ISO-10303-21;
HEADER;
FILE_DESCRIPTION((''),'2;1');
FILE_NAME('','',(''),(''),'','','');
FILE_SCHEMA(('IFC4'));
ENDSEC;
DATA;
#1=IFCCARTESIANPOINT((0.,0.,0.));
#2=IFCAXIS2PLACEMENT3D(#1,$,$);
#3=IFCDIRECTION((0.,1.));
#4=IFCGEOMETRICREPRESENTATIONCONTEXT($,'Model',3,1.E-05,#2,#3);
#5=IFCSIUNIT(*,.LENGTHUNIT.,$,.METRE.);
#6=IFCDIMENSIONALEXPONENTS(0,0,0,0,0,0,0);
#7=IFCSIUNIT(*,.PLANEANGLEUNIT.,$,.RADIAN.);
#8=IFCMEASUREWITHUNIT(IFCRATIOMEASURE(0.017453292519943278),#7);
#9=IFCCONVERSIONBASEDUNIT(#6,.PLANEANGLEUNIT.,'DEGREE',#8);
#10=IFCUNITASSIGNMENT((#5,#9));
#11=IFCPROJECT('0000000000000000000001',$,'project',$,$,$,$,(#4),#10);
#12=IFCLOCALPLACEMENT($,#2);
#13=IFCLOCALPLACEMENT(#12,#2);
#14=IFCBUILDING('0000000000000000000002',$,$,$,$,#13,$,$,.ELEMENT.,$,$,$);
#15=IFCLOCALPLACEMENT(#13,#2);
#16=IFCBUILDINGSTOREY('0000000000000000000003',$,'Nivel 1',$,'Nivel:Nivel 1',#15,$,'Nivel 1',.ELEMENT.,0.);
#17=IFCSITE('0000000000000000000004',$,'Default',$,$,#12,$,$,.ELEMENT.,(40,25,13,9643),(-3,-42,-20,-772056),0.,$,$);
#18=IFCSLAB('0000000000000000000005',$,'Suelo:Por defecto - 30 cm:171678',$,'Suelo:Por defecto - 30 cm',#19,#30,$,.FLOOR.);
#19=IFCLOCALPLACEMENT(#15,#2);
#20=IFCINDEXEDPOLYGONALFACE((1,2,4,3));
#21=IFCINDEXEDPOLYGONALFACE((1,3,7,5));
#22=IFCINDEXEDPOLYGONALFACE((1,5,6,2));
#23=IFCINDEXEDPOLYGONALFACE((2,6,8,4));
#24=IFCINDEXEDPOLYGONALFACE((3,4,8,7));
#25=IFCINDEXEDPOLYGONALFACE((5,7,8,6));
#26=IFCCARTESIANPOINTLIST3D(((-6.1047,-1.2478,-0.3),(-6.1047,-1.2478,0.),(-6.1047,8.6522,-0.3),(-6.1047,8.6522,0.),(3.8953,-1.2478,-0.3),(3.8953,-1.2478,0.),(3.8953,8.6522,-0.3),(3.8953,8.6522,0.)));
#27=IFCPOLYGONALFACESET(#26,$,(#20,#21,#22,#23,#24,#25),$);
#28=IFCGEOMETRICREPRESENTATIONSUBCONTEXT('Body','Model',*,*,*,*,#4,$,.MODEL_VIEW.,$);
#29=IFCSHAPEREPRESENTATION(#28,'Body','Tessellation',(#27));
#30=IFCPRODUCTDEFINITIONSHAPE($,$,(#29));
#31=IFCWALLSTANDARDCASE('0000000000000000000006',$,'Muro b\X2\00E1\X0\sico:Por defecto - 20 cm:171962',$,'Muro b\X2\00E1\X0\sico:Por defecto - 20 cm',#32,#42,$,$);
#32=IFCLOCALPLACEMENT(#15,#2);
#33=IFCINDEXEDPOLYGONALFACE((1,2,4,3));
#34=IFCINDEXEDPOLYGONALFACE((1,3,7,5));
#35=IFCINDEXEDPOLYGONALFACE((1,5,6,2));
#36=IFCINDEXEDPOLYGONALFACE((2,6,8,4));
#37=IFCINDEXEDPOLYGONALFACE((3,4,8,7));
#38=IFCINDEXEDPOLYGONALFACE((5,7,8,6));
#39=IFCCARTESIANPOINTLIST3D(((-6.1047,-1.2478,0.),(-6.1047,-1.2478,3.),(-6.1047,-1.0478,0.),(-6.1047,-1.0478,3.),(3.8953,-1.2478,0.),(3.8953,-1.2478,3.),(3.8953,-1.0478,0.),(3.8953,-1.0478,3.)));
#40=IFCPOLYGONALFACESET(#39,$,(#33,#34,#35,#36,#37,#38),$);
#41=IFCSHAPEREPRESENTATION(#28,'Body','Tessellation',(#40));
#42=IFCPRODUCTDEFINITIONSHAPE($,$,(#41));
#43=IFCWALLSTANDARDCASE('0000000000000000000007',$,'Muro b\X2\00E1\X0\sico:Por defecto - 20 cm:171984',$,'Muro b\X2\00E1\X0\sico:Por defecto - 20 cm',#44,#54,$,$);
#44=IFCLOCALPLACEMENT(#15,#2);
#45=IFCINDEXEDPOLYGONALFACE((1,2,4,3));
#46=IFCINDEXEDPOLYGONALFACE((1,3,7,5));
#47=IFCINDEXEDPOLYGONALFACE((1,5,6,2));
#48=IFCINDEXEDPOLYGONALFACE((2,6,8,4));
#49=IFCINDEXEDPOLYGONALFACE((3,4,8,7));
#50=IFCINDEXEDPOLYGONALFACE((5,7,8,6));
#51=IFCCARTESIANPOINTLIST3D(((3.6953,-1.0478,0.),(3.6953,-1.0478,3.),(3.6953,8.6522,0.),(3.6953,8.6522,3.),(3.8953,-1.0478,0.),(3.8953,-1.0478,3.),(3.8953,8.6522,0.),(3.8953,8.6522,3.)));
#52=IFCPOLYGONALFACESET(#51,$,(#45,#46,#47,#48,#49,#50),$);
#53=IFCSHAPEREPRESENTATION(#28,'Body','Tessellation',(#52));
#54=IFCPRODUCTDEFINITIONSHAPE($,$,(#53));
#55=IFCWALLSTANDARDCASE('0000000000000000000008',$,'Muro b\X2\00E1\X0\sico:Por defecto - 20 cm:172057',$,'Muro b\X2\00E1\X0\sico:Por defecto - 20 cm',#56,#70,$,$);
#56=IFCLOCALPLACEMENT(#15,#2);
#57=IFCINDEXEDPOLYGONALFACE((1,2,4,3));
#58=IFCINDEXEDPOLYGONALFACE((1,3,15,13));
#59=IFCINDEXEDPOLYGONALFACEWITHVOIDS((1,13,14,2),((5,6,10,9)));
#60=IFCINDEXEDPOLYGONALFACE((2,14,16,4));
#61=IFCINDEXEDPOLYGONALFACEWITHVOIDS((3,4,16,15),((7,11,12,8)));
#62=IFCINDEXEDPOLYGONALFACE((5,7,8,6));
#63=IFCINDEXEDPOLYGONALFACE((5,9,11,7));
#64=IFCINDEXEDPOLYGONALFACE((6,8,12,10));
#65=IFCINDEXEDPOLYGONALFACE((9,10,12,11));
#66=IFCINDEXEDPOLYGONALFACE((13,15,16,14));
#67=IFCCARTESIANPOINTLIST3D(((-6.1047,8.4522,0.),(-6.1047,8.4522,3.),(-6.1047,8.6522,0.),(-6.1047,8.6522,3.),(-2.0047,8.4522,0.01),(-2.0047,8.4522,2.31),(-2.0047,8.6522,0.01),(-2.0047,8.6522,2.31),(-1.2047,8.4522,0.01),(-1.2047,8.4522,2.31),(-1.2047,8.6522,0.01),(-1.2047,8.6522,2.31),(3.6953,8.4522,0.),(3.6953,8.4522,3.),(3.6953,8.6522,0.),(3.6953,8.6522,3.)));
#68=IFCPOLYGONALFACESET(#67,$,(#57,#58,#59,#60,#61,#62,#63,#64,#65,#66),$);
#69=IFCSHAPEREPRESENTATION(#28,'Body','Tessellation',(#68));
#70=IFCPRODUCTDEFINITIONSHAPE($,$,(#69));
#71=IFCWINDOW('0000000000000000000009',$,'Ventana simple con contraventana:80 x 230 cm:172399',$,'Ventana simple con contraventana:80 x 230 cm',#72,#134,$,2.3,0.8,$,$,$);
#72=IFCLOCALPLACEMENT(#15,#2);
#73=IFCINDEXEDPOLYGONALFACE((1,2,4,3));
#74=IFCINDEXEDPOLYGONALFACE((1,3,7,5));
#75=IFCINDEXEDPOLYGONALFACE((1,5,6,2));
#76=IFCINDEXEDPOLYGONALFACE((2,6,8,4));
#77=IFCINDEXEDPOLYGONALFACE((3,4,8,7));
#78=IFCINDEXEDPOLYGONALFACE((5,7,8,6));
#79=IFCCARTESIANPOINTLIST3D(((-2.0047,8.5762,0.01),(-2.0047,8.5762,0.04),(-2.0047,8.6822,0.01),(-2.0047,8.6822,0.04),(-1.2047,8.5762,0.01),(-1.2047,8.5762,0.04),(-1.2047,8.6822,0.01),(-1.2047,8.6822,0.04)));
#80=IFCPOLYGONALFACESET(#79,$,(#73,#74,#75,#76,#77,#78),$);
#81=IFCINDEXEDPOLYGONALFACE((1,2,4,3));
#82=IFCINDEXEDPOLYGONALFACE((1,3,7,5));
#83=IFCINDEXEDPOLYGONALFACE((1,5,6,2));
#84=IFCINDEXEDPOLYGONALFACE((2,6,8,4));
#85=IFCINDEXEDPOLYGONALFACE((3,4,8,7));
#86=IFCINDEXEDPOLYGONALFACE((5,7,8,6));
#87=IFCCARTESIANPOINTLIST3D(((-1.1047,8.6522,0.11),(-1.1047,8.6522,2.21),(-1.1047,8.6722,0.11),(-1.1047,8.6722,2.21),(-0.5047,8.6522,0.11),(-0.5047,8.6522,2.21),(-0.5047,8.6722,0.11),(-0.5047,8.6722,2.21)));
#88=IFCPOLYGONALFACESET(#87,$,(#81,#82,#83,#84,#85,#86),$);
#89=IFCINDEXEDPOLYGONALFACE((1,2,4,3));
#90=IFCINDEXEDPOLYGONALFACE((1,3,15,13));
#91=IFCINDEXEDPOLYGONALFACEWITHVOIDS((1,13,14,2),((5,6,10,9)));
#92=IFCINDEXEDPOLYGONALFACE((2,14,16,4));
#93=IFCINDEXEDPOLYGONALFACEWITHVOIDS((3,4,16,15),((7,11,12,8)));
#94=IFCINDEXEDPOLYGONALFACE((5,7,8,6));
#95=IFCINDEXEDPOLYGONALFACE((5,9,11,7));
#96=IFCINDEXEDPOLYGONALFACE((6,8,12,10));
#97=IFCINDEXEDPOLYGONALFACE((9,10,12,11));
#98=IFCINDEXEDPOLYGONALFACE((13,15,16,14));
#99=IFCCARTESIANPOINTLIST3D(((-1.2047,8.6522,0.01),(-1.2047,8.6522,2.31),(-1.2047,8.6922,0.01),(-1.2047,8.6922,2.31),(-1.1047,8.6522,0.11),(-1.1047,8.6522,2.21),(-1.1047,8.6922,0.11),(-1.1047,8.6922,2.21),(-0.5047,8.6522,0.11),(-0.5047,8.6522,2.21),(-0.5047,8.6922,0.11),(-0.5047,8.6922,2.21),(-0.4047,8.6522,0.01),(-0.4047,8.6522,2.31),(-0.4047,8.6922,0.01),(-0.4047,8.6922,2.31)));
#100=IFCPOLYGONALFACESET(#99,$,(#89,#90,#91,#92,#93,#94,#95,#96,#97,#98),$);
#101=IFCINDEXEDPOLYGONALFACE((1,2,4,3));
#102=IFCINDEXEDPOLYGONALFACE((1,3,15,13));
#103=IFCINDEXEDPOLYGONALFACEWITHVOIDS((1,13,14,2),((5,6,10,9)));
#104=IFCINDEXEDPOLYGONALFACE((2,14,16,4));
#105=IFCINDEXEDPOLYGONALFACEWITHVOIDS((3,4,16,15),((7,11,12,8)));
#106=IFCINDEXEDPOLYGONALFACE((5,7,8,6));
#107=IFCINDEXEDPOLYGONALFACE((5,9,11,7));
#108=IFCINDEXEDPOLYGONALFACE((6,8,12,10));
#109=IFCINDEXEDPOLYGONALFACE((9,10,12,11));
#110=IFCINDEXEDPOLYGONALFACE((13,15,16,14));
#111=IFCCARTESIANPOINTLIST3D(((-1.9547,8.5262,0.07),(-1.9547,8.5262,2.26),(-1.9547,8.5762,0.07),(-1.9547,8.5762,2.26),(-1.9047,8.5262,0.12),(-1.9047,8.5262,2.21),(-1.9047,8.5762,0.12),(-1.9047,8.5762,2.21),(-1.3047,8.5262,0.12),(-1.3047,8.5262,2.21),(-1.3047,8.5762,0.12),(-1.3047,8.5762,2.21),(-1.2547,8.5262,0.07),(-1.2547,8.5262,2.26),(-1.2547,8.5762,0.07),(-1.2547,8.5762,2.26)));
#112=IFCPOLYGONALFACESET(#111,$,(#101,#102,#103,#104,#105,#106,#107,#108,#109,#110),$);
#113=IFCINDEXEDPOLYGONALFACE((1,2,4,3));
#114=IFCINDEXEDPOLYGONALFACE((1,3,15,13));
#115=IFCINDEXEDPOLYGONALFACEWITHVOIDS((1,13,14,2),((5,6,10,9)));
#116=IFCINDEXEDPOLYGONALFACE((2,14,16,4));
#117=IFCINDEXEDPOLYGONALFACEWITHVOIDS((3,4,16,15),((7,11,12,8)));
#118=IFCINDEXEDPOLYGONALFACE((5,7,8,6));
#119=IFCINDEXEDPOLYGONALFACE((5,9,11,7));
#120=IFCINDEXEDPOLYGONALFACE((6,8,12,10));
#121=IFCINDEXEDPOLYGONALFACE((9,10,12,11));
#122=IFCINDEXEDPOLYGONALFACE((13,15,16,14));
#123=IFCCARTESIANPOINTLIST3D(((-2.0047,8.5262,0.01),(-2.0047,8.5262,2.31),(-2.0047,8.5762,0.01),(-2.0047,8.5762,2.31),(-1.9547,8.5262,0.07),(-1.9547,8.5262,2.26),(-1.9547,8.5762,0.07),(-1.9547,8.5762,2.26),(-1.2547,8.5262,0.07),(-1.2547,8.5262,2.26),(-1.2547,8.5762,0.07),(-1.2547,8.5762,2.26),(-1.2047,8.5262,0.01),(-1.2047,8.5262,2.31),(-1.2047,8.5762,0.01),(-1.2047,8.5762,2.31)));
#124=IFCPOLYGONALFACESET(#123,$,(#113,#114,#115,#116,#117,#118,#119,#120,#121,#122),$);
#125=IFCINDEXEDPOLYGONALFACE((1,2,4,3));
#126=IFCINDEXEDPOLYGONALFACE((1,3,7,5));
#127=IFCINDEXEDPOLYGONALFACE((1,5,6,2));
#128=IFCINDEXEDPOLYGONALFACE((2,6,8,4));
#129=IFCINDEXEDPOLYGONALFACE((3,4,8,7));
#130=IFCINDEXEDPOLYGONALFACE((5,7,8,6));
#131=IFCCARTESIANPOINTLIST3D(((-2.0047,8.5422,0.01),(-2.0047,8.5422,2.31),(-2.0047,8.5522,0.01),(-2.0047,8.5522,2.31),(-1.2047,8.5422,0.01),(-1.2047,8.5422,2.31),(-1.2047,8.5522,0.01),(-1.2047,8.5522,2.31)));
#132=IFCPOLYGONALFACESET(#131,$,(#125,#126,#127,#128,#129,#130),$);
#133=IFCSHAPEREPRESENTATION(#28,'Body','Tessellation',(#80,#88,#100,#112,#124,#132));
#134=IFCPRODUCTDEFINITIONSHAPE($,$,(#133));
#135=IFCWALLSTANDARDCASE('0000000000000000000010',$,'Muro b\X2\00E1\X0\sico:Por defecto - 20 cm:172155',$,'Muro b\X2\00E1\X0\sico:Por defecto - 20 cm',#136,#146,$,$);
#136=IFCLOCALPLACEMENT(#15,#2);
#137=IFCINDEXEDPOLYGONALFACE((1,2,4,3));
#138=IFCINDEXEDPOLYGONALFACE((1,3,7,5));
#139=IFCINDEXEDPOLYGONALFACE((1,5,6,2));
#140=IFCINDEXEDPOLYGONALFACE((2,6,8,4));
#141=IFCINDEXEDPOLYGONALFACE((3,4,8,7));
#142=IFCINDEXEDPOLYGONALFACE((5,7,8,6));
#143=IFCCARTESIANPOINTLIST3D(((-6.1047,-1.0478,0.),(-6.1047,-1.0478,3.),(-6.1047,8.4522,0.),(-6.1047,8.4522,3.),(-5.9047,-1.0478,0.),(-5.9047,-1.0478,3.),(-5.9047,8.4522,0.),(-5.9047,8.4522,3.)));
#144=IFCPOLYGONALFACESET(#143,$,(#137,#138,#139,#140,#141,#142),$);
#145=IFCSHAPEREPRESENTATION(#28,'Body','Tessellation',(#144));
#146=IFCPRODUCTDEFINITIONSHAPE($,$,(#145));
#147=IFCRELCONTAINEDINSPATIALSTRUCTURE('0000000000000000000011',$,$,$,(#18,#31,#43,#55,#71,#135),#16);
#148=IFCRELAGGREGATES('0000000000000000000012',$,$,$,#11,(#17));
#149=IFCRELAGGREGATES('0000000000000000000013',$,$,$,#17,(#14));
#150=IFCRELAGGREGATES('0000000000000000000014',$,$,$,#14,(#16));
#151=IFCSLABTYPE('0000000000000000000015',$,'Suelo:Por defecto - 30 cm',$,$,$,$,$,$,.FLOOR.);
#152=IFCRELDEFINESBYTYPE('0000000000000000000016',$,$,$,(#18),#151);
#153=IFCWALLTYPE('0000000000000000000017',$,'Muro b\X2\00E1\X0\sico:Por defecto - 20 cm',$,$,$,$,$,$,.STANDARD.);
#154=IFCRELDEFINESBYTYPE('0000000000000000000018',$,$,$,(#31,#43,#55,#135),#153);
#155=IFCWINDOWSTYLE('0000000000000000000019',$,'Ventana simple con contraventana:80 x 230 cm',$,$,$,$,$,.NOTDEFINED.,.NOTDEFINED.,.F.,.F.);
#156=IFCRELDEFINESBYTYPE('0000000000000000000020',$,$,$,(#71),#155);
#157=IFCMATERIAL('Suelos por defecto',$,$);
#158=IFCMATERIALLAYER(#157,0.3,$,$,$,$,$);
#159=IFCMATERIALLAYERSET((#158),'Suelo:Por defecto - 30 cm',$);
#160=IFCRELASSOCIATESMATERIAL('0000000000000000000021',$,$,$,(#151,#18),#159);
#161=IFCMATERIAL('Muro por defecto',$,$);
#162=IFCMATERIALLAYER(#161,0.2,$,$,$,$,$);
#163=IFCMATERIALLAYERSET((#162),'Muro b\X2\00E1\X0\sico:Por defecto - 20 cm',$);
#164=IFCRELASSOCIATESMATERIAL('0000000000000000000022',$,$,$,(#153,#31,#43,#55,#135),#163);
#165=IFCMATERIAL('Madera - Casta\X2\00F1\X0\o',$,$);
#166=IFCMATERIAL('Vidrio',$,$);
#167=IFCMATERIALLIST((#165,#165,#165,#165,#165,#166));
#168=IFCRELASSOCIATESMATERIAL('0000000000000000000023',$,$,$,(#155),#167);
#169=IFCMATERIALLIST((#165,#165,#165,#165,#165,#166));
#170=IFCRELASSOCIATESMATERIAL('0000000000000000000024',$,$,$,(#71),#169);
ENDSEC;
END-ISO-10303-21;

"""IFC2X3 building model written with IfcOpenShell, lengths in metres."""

from ifc_helpers import new_model, entity, si_unit, converted_unit, direction, frame, frame_2d, origin, origin_2d_with_axis, place, context, subcontext, project, spatial, polyline, rectangle, outline, extrude, source, transform, mapped, material, material_list, layer, layer_set, layer_usage, type_object, type_shapes, element, fill, save


model = new_model("IFC2X3")

# Units and contexts
model_context = context("Model", 3, precision=1e-05, world=origin(), true_north=direction((0.0, 1.0)))
body_context = subcontext(model_context, "Body", "Model", "MODEL_VIEW")
ifc_project = project(units=[si_unit("LENGTHUNIT", "METRE"), converted_unit("PLANEANGLEUNIT", "DEGREE", entity("IfcRatioMeasure", 0.017453292519943278), si_unit("PLANEANGLEUNIT", "RADIAN"), dimensions=[0, 0, 0, 0, 0, 0, 0])], contexts=[model_context])

# Site, building, storey
site_placement = place(None, origin())
site = spatial("IfcSite", under=ifc_project, at=site_placement, Name="Default", CompositionType="ELEMENT", RefLatitude=(40, 25, 13, 9643), RefLongitude=(-3, -42, -20, -772056), RefElevation=0.0)
building_placement = place(site_placement, origin())
building = spatial("IfcBuilding", under=site, at=building_placement, CompositionType="ELEMENT")
storey_placement = place(building_placement, origin())
storey = spatial("IfcBuildingStorey", under=building, at=storey_placement, Name="Nivel 1", ObjectType="Nivel:Nivel 1", LongName="Nivel 1", CompositionType="ELEMENT", Elevation=0.0)

# Slab
ifc_material_1 = material(Name="Suelos por defecto")
ifc_layer_1 = layer(ifc_material_1, 0.3)
ifc_layer_set_1 = layer_set([ifc_layer_1], Name="Suelo:Por defecto - 30 cm")
ifc_layer_usage_1 = layer_usage(ifc_layer_set_1, "AXIS3", "POSITIVE", 0.0)
slab_type = type_object("IfcSlabType", Name="Suelo:Por defecto - 30 cm", PredefinedType="FLOOR", material=ifc_layer_set_1)
slab_placement = place(storey_placement, origin())
element("IfcSlab", 1, at=slab_placement, inside=storey, type_object=slab_type, material=ifc_layer_usage_1, Name="Suelo:Por defecto - 30 cm:171678", ObjectType="Suelo:Por defecto - 30 cm", PredefinedType="FLOOR", context=body_context, shape_type="SweptSolid", body=[
    extrude(rectangle(XDim=9.9, YDim=10.0, at=origin_2d_with_axis()), frame((-1.1047, 3.7022, 0.0), z_axis=(0.0, 0.0, -1.0), x_axis=(0.0, 1.0, 0.0)), (0.0, 0.0, 1.0), 0.3),
])

# Walls
ifc_material_2 = material(Name="Muro por defecto")
ifc_layer_2 = layer(ifc_material_2, 0.2)
ifc_layer_set_2 = layer_set([ifc_layer_2], Name="Muro básico:Por defecto - 20 cm")
ifc_layer_usage_2 = layer_usage(ifc_layer_set_2, "AXIS2", "NEGATIVE", 0.1)
wall_type = type_object("IfcWallType", Name="Muro básico:Por defecto - 20 cm", PredefinedType="STANDARD", material=ifc_layer_set_2)
wall_1_placement = place(storey_placement, frame((-6.1047, -1.1478, 0.0)))
element("IfcWallStandardCase", 2, at=wall_1_placement, inside=storey, type_object=wall_type, material=ifc_layer_usage_2, Name="Muro básico:Por defecto - 20 cm:171962", ObjectType="Muro básico:Por defecto - 20 cm", context=body_context, shape_type="SweptSolid", body=[
    extrude(rectangle(XDim=10.0, YDim=0.2, at=frame_2d((5.0, 0.0), x_axis=(-1.0, 0.0))), origin(), (0.0, 0.0, 1.0), 3.0),
])
ifc_layer_usage_3 = layer_usage(ifc_layer_set_2, "AXIS2", "NEGATIVE", 0.1)
wall_2_placement = place(storey_placement, frame((3.7953, -1.0478, 0.0), z_axis=(0.0, 0.0, 1.0), x_axis=(0.0, 1.0, 0.0)))
element("IfcWallStandardCase", 3, at=wall_2_placement, inside=storey, type_object=wall_type, material=ifc_layer_usage_3, Name="Muro básico:Por defecto - 20 cm:171984", ObjectType="Muro básico:Por defecto - 20 cm", context=body_context, shape_type="SweptSolid", body=[
    extrude(rectangle(XDim=9.7, YDim=0.2, at=frame_2d((4.85, 0.0), x_axis=(-1.0, 0.0))), origin(), (0.0, 0.0, 1.0), 3.0),
])

# Wall, opening, window
ifc_layer_usage_4 = layer_usage(ifc_layer_set_2, "AXIS2", "NEGATIVE", 0.1)
wall_3_placement = place(storey_placement, frame((3.6953, 8.5522, 0.0), z_axis=(0.0, 0.0, 1.0), x_axis=(-1.0, 0.0, 0.0)))
wall_3 = element("IfcWallStandardCase", 4, at=wall_3_placement, inside=storey, type_object=wall_type, material=ifc_layer_usage_4, Name="Muro básico:Por defecto - 20 cm:172057", ObjectType="Muro básico:Por defecto - 20 cm", context=body_context, shape_type="SweptSolid", body=[
    extrude(rectangle(XDim=9.8, YDim=0.2, at=frame_2d((4.9, 0.0), x_axis=(-1.0, 0.0))), origin(), (0.0, 0.0, 1.0), 3.0),
])
opening_placement = place(wall_3_placement, frame((5.7, 0.1, 0.01)))
opening = element("IfcOpeningElement", 5, at=opening_placement, cuts=wall_3, ObjectType="Opening", context=body_context, shape_type="SweptSolid", body=[
    extrude(rectangle(XDim=2.3, YDim=0.8, at=frame_2d((1.15, 0.4), x_axis=(1.0, 0.0))), frame((0.0, 0.0, 0.0), z_axis=(0.0, -1.0, 0.0), x_axis=(0.0, 0.0, 1.0)), (0.0, 0.0, 1.0), 0.2),
])
ifc_material_3 = material(Name="Madera - Castaño")
ifc_material_4 = material(Name="Vidrio")
ifc_material_list_1 = material_list([ifc_material_3, ifc_material_3, ifc_material_3, ifc_material_3, ifc_material_3, ifc_material_4])
ifc_material_list_2 = material_list([ifc_material_3, ifc_material_3, ifc_material_3, ifc_material_3, ifc_material_3, ifc_material_4])
window_style = type_object("IfcWindowStyle", Name="Ventana simple con contraventana:80 x 230 cm", ConstructionType="NOTDEFINED", OperationType="NOTDEFINED", ParameterTakesPrecedence=False, Sizeable=False, material=ifc_material_list_2)
shared_shape = source(origin(), body_context, "Body", "SweptSolid", [
    extrude(rectangle(XDim=0.8, YDim=0.106, at=frame_2d((0.0, 0.0), x_axis=(1.0, 0.0))), frame((0.4, 0.177, 0.0)), (0.0, 0.0, 1.0), 0.03),
    extrude(rectangle(XDim=0.02, YDim=0.6, at=frame_2d((0.0, 0.0), x_axis=(1.0, 0.0))), frame((1.2, 0.21, 0.1), z_axis=(0.0, 0.0, 1.0), x_axis=(0.0, 1.0, 0.0)), (0.0, 0.0, 1.0), 2.1),
    extrude(outline(polyline([(-1.15, -0.4), (1.15, -0.4), (1.15, 0.4), (-1.15, 0.4), (-1.15, -0.4)]), holes=[polyline([(-1.05, 0.3), (1.05, 0.3), (1.05, -0.3), (-1.05, -0.3), (-1.05, 0.3)])]), frame((1.2, 0.2, 1.15), z_axis=(0.0, 1.0, 0.0), x_axis=(0.0, 0.0, -1.0)), (0.0, 0.0, 1.0), 0.04),
    extrude(outline(polyline([(-1.095, -0.35), (1.095, -0.35), (1.095, 0.35), (-1.095, 0.35), (-1.095, -0.35)]), holes=[polyline([(-1.045, -0.3), (-1.045, 0.3), (1.045, 0.3), (1.045, -0.3), (-1.045, -0.3)])]), frame((0.4, 0.074, 1.155), z_axis=(0.0, 1.0, 0.0), x_axis=(0.0, 0.0, -1.0)), (0.0, 0.0, 1.0), 0.05),
    extrude(outline(polyline([(-0.4, -1.15), (0.4, -1.15), (0.4, 1.15), (-0.4, 1.15), (-0.4, -1.15)]), holes=[polyline([(-0.35, -1.1), (-0.35, 1.09), (0.35, 1.09), (0.35, -1.1), (-0.35, -1.1)])]), frame((0.4, 0.074, 1.15), z_axis=(0.0, 1.0, 0.0), x_axis=(1.0, 0.0, 0.0)), (0.0, 0.0, 1.0), 0.05),
    extrude(rectangle(XDim=0.01, YDim=0.8, at=origin_2d_with_axis()), frame((0.4, 0.095, 0.0), z_axis=(0.0, 0.0, 1.0), x_axis=(0.0, 1.0, 0.0)), (0.0, 0.0, 1.0), 2.3),
])
type_shapes(window_style, [shared_shape])
window_placement = place(opening_placement, frame((0.0, 0.0, 0.0), z_axis=(0.0, 0.0, 1.0), x_axis=(-1.0, 0.0, 0.0)))
window = element("IfcWindow", 6, at=window_placement, inside=storey, type_object=window_style, material=ifc_material_list_1, Name="Ventana simple con contraventana:80 x 230 cm:172399", ObjectType="Ventana simple con contraventana:80 x 230 cm", OverallHeight=2.3, OverallWidth=0.8, context=body_context, shape_type="MappedRepresentation", body=[
    mapped(shared_shape, transform((0.0, 0.0, 0.0), scale=1.0)),
])
fill(opening, window)

# Wall
ifc_layer_usage_5 = layer_usage(ifc_layer_set_2, "AXIS2", "NEGATIVE", 0.1)
wall_4_placement = place(storey_placement, frame((-6.0047, 8.4522, 0.0), z_axis=(0.0, 0.0, 1.0), x_axis=(0.0, -1.0, 0.0)))
element("IfcWallStandardCase", 7, at=wall_4_placement, inside=storey, type_object=wall_type, material=ifc_layer_usage_5, Name="Muro básico:Por defecto - 20 cm:172155", ObjectType="Muro básico:Por defecto - 20 cm", context=body_context, shape_type="SweptSolid", body=[
    extrude(rectangle(XDim=9.5, YDim=0.2, at=frame_2d((4.75, 0.0), x_axis=(-1.0, 0.0))), origin(), (0.0, 0.0, 1.0), 3.0),
])

save(model, "model.ifc")
